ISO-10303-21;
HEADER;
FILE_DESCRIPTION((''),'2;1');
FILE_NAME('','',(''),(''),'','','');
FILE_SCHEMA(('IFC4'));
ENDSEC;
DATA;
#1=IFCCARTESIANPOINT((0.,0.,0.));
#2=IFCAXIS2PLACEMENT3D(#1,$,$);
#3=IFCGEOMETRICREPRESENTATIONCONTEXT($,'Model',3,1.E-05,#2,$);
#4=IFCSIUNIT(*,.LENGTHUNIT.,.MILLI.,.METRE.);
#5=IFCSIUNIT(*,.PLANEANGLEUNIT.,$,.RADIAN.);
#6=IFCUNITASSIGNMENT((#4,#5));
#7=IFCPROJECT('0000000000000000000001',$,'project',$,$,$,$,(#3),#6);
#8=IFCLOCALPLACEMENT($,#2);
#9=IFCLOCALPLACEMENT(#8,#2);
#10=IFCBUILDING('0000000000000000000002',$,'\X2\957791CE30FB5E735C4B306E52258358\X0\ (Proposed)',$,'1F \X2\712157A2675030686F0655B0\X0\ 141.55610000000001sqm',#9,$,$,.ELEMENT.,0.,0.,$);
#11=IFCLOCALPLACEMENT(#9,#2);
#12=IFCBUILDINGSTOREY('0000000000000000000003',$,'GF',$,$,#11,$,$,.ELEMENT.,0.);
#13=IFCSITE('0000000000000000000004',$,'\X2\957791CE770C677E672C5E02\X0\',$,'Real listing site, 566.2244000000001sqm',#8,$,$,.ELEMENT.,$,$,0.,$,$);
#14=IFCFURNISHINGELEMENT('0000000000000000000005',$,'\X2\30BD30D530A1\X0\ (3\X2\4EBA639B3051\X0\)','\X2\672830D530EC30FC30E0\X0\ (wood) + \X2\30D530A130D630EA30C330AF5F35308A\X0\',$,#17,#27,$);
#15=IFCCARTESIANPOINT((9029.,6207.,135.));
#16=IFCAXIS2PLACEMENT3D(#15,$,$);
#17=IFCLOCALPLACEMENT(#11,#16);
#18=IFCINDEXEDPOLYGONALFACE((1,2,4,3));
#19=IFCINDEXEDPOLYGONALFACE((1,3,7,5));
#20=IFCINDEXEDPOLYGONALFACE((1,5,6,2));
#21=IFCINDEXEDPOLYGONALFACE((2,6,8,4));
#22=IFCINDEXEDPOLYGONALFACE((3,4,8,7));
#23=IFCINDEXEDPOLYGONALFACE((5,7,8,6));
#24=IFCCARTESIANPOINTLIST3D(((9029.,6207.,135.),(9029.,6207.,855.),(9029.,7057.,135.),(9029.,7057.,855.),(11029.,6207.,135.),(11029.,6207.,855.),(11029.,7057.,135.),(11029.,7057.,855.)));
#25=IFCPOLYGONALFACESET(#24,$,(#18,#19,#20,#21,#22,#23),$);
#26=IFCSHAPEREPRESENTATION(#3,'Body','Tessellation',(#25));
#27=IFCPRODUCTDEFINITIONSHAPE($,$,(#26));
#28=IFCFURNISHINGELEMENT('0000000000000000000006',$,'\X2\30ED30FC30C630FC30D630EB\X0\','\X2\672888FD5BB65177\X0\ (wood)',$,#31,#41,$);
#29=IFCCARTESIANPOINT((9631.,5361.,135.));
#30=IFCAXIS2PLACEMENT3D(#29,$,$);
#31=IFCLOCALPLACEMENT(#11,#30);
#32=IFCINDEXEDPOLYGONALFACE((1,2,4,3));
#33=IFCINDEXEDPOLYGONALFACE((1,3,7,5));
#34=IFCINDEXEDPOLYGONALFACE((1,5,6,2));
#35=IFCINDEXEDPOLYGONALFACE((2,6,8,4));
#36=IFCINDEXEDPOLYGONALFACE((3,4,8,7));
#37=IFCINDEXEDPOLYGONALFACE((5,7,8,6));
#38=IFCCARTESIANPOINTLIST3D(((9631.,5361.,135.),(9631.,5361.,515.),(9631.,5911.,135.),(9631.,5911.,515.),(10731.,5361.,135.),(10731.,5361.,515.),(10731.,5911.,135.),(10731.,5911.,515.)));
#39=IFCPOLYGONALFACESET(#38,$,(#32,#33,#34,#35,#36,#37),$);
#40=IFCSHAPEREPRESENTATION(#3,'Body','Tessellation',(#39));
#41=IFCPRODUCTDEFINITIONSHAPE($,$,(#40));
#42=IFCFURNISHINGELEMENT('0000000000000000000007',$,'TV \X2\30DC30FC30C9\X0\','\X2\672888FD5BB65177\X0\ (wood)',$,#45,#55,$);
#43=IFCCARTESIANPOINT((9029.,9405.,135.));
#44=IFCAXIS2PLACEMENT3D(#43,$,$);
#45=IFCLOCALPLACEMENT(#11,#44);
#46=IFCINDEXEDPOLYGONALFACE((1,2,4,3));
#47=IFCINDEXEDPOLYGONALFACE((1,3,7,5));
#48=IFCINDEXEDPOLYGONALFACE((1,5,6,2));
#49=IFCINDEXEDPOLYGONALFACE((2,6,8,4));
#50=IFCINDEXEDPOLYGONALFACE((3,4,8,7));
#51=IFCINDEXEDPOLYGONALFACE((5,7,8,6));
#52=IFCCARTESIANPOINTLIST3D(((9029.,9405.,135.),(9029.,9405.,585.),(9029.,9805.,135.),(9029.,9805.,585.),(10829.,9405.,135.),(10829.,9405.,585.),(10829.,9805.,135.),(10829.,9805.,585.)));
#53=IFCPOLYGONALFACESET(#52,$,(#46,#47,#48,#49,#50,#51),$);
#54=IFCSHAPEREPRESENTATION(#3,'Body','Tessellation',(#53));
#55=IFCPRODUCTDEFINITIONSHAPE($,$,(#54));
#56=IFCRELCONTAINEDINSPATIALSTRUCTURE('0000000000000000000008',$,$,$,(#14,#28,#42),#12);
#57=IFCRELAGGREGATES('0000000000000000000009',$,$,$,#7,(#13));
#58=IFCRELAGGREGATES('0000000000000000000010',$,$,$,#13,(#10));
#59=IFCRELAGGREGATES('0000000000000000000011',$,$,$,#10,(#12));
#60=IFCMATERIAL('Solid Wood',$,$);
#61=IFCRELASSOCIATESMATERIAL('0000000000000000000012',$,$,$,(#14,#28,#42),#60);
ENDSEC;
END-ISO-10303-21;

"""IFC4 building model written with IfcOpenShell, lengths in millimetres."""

from ifc_helpers import new_model, si_unit, frame, frame_2d, origin, place, context, project, spatial, rectangle, extrude, material, element, save


model = new_model("IFC4")

# Units and contexts
model_context = context("Model", 3, precision=1e-05, world=origin())
ifc_project = project(units=[si_unit("LENGTHUNIT", "METRE", prefix="MILLI"), si_unit("PLANEANGLEUNIT", "RADIAN")], contexts=[model_context])

# Site, building, storey
site_placement = place(None, origin())
site = spatial("IfcSite", under=ifc_project, at=site_placement, Name="長野県松本市", ObjectType="Real listing site, 566.2244000000001sqm", CompositionType="ELEMENT", RefElevation=0.0)
building_placement = place(site_placement, origin())
building = spatial("IfcBuilding", under=site, at=building_placement, Name="長野・平屋の別荘 (Proposed)", ObjectType="1F 無垢材と漆喰 141.55610000000001sqm", CompositionType="ELEMENT", ElevationOfRefHeight=0.0, ElevationOfTerrain=0.0)
storey_placement = place(building_placement, origin())
storey = spatial("IfcBuildingStorey", under=building, at=storey_placement, Name="GF", CompositionType="ELEMENT", Elevation=0.0)

# Shared definitions
ifc_material_1 = material(Name="Solid Wood")

# Furnishing elements
furnishing_1_placement = place(storey_placement, frame((9029.0, 6207.0, 135.0)))
element("IfcFurnishingElement", 1, at=furnishing_1_placement, inside=storey, material=ifc_material_1, Name="ソファ (3人掛け)", Description="木フレーム (wood) + ファブリック張り", context=model_context, shape_type="SweptSolid", body=[
    extrude(rectangle(XDim=2000.0, YDim=850.0, at=frame_2d((1000.0, 425.0))), frame((9029.0, 6207.0, 135.0)), (0.0, 0.0, 1.0), 720.0),
])
furnishing_2_placement = place(storey_placement, frame((9631.0, 5361.0, 135.0)))
element("IfcFurnishingElement", 2, at=furnishing_2_placement, inside=storey, material=ifc_material_1, Name="ローテーブル", Description="木製家具 (wood)", context=model_context, shape_type="SweptSolid", body=[
    extrude(rectangle(XDim=1100.0, YDim=550.0, at=frame_2d((550.0, 275.0))), frame((9631.0, 5361.0, 135.0)), (0.0, 0.0, 1.0), 380.0),
])
furnishing_3_placement = place(storey_placement, frame((9029.0, 9405.0, 135.0)))
element("IfcFurnishingElement", 3, at=furnishing_3_placement, inside=storey, material=ifc_material_1, Name="TV ボード", Description="木製家具 (wood)", context=model_context, shape_type="SweptSolid", body=[
    extrude(rectangle(XDim=1800.0, YDim=400.0, at=frame_2d((900.0, 200.0))), frame((9029.0, 9405.0, 135.0)), (0.0, 0.0, 1.0), 450.0),
])

save(model, "model.ifc")
